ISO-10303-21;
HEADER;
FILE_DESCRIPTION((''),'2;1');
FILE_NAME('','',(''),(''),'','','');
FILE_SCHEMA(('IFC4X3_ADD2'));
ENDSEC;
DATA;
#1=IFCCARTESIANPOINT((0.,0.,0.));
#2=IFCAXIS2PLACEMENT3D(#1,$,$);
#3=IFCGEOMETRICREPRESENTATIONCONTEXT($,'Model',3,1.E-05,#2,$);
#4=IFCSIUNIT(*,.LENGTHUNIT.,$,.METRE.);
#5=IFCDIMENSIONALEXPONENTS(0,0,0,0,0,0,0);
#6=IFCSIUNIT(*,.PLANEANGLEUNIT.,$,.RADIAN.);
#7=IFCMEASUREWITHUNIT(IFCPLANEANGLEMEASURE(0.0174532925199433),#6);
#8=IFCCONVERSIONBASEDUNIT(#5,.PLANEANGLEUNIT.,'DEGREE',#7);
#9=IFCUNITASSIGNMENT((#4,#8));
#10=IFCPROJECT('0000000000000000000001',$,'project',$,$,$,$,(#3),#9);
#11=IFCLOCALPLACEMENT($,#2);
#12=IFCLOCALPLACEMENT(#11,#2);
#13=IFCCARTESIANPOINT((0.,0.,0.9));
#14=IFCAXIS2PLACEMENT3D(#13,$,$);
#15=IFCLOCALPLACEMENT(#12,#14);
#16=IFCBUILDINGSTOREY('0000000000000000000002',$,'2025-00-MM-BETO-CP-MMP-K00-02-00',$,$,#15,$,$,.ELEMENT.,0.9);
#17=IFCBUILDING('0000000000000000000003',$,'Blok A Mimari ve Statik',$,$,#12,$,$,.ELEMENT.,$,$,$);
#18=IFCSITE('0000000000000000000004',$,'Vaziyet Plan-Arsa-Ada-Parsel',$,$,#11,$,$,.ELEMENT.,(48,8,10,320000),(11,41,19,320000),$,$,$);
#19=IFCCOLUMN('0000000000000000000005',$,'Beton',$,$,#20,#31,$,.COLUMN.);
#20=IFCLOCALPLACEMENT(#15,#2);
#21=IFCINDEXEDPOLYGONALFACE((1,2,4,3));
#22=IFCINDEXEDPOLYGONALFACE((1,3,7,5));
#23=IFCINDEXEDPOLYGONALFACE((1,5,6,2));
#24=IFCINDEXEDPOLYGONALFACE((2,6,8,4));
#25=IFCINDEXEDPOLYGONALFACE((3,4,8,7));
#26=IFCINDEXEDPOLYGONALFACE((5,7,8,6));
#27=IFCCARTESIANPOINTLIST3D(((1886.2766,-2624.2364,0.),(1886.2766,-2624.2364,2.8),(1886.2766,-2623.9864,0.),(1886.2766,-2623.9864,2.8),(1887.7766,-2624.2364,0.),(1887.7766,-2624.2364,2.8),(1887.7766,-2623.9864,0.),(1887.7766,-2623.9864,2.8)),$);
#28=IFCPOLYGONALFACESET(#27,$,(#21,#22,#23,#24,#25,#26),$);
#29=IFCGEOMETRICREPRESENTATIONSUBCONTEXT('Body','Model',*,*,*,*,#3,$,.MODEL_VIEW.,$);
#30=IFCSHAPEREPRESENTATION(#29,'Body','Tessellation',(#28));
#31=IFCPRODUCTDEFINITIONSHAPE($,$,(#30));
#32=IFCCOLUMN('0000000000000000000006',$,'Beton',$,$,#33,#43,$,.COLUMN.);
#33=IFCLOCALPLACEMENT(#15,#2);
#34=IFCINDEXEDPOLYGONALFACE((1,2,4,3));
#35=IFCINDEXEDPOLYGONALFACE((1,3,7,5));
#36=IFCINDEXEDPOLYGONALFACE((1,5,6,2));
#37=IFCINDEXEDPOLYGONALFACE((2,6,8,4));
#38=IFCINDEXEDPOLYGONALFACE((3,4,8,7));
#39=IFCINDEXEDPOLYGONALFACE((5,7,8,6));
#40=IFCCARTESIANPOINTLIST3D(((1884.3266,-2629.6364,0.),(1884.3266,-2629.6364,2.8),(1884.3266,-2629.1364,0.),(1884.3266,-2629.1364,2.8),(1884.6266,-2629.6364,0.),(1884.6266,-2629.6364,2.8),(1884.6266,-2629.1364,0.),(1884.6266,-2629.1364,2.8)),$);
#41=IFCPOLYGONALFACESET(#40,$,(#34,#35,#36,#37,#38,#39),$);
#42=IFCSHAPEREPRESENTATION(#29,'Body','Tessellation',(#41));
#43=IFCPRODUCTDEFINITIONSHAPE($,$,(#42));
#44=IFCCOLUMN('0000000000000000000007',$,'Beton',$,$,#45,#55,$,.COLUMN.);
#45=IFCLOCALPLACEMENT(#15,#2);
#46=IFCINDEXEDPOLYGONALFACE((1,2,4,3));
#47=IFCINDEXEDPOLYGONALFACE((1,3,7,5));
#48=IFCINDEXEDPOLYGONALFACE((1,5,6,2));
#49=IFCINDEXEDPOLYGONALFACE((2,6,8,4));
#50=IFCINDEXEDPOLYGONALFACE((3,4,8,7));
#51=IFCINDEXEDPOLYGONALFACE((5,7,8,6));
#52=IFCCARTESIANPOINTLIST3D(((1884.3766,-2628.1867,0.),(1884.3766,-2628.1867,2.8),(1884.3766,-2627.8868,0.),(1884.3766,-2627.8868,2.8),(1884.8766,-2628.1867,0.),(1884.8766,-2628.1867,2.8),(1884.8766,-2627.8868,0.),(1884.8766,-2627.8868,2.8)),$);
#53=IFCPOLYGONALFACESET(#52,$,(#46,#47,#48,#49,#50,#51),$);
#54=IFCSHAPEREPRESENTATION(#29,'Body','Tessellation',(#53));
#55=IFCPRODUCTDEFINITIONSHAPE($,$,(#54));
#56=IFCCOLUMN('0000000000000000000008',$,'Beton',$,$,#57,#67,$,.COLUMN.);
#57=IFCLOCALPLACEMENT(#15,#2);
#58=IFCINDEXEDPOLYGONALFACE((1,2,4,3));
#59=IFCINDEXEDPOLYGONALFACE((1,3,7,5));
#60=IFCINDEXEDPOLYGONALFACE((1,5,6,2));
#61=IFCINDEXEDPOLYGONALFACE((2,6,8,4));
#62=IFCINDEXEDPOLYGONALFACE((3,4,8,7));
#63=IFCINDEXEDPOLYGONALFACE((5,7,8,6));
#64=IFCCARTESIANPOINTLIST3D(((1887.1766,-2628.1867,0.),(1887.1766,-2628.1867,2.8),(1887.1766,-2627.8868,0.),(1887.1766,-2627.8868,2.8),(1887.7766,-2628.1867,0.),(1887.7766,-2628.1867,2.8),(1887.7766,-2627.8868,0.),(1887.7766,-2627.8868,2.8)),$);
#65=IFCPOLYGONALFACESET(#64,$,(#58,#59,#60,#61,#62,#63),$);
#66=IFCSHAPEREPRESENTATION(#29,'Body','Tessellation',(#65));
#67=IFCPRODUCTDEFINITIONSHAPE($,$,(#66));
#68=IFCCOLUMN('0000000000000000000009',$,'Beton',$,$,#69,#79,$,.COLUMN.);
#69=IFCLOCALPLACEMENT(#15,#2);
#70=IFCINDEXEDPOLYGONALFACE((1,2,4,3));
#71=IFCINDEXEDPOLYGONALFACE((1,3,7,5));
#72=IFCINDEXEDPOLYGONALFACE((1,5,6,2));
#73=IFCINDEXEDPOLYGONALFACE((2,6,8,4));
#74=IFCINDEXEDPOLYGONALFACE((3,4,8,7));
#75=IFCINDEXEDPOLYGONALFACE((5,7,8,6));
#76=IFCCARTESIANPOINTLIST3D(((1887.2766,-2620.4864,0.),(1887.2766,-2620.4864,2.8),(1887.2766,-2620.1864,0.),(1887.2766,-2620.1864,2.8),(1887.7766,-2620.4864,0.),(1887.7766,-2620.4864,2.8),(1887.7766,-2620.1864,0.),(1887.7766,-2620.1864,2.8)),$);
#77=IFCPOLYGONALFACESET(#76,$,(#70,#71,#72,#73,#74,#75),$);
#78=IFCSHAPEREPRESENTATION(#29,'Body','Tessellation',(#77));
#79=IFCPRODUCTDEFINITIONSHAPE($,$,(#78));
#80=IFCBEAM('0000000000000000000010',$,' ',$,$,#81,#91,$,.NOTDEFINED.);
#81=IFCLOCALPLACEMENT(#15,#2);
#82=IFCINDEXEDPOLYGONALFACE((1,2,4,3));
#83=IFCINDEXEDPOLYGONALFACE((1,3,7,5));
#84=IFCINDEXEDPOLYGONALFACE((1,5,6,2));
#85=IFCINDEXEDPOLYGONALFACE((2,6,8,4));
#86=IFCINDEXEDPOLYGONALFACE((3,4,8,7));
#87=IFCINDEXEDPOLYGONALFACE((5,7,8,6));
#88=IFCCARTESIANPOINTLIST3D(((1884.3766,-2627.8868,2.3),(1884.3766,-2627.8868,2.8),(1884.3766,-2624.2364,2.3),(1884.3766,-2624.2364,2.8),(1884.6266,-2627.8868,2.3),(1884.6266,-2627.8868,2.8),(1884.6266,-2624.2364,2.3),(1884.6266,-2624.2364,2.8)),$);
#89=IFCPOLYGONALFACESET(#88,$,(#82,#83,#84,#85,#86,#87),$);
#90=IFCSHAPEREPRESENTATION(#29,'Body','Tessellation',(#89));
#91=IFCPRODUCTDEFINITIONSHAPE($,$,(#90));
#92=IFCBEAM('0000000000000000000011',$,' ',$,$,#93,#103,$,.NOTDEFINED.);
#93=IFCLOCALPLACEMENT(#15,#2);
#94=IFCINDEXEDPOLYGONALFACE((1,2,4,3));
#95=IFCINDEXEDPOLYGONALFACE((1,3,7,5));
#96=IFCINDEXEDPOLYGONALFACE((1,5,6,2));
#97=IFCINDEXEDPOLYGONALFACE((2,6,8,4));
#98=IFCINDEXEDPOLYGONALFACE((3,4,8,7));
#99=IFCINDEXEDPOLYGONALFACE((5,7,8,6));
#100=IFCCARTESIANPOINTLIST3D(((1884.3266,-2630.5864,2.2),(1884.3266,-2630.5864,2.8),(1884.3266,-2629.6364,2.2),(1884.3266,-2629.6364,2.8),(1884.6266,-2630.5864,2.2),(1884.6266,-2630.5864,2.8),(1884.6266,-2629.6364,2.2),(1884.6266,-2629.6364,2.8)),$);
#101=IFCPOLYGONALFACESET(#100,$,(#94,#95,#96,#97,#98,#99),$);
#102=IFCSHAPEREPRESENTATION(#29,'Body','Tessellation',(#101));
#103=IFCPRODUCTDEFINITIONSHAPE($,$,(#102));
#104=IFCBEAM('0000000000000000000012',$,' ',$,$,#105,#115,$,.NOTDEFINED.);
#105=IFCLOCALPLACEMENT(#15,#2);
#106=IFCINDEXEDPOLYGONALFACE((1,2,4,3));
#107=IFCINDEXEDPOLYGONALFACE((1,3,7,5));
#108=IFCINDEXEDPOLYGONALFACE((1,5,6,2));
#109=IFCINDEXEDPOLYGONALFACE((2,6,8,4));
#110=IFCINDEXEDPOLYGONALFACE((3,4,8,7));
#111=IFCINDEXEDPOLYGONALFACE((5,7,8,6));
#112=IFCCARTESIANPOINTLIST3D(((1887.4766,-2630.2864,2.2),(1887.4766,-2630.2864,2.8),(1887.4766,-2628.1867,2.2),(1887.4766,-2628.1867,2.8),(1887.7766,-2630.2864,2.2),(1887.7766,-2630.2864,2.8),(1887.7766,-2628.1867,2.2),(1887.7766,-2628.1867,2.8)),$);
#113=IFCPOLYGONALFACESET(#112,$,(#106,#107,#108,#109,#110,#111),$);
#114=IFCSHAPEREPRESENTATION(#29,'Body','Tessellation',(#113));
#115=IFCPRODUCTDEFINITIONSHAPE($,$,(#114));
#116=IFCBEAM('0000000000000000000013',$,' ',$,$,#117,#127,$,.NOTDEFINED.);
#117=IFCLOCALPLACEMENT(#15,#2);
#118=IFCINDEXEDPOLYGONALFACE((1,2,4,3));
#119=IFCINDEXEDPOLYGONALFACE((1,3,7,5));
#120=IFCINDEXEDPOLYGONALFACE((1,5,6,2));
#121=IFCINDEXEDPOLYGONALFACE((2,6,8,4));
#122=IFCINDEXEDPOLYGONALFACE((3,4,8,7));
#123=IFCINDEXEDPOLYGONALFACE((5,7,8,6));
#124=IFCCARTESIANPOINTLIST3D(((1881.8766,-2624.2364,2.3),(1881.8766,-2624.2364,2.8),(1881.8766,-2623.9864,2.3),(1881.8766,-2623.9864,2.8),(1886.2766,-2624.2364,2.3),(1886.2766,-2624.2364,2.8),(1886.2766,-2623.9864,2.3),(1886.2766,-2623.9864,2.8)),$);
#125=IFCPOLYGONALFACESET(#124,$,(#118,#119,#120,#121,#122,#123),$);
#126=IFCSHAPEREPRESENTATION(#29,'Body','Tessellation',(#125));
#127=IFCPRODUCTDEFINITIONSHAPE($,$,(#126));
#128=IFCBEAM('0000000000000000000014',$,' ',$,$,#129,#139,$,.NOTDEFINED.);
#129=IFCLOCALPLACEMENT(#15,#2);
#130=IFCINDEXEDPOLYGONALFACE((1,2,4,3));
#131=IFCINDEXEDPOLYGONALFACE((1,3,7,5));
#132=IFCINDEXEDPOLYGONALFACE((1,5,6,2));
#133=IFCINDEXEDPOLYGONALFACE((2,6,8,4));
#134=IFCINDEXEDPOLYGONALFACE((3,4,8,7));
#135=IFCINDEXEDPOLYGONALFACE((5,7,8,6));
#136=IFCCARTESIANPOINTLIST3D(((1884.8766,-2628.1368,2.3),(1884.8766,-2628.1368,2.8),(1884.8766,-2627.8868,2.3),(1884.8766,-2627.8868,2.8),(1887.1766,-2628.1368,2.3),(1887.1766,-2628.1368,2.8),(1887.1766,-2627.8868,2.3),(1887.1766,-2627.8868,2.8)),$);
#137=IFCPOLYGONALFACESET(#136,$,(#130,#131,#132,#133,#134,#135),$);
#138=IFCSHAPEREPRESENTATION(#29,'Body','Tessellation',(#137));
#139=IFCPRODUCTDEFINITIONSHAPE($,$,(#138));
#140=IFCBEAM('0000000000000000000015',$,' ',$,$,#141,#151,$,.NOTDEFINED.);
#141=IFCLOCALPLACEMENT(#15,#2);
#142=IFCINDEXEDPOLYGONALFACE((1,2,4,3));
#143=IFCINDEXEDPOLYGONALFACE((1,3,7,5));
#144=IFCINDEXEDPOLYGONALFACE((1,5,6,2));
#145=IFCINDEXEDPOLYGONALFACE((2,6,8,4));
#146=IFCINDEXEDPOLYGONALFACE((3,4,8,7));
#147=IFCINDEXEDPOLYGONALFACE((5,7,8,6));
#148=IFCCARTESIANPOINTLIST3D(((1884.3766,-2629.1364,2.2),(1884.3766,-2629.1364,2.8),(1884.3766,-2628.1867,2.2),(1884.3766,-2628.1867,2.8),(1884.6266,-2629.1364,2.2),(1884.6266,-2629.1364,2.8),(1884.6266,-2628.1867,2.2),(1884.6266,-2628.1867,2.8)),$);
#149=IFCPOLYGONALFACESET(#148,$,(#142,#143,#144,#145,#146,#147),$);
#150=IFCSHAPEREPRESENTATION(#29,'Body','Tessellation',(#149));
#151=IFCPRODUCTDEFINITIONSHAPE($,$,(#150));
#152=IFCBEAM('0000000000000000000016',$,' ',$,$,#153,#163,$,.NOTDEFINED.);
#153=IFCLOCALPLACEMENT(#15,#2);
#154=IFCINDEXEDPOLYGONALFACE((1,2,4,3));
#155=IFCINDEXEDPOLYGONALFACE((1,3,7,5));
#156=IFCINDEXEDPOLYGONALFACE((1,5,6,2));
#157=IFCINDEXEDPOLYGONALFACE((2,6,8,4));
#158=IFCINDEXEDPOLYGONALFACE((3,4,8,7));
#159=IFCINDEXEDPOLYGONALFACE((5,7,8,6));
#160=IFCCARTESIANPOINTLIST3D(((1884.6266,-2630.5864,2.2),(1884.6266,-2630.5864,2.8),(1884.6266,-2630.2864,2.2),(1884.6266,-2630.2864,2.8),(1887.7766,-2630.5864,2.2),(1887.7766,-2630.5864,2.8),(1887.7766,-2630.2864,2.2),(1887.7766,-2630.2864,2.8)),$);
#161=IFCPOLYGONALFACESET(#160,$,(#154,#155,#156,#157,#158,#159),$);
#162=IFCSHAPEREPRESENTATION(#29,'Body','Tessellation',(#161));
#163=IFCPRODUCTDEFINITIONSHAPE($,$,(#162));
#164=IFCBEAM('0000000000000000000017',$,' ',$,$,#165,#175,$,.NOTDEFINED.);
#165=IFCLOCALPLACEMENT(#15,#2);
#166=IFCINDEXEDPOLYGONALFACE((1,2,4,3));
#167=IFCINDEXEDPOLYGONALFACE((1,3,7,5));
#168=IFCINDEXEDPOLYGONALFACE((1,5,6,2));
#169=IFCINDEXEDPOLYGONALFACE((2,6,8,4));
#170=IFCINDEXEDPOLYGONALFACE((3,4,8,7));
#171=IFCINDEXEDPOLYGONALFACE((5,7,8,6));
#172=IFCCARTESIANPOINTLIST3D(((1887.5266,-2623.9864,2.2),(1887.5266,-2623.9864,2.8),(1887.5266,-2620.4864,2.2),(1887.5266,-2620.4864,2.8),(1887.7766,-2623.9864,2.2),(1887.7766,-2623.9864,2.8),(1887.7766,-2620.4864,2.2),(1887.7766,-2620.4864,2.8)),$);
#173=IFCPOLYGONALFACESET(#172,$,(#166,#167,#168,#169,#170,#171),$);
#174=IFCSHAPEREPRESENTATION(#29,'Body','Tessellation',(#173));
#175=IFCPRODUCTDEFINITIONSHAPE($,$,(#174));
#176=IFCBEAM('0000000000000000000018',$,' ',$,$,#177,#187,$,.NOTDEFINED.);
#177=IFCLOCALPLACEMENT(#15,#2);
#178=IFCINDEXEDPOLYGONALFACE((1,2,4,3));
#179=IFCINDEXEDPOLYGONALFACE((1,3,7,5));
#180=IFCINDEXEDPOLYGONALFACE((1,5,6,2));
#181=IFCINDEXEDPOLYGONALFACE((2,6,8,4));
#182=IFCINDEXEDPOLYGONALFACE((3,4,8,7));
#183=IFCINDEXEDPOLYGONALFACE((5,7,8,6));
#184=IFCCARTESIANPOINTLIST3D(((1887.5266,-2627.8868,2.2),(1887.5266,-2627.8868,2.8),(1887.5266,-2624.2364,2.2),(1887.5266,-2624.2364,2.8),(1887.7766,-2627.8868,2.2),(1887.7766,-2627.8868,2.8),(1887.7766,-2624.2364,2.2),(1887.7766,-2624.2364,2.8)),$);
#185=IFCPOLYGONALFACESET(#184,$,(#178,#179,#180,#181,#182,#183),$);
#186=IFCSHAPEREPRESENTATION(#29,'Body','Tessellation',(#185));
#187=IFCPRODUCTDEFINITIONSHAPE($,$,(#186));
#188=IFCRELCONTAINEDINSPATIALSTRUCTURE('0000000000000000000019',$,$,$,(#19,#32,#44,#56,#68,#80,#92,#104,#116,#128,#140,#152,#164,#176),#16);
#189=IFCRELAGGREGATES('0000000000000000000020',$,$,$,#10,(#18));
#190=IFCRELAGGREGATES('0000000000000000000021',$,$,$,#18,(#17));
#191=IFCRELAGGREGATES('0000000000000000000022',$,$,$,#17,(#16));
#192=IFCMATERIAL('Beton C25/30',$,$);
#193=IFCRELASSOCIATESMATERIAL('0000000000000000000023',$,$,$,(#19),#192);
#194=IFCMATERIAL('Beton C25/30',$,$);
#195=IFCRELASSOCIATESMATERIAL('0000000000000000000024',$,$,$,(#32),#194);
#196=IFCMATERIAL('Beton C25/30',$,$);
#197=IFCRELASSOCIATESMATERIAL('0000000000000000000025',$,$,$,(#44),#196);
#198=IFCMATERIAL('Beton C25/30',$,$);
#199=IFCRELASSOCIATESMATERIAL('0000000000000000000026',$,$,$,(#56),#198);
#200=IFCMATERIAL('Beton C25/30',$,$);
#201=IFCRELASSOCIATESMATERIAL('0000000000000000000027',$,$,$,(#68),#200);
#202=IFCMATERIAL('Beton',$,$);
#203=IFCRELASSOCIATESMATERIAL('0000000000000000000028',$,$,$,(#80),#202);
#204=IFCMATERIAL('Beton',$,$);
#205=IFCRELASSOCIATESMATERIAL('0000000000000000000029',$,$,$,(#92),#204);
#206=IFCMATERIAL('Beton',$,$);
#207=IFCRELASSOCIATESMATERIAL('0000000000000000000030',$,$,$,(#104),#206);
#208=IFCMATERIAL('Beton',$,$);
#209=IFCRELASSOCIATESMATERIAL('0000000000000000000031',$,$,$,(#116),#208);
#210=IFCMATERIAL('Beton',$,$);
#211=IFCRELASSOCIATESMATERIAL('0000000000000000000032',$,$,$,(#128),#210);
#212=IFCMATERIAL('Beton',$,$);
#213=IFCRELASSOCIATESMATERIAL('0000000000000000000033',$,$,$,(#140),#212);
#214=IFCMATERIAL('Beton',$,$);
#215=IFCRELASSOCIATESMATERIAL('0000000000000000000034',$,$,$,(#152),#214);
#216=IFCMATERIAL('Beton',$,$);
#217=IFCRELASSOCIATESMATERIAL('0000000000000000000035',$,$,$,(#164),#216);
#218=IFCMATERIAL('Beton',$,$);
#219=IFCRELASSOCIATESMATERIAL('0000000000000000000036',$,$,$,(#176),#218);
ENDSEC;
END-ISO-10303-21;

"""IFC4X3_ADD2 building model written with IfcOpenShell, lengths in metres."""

from ifc_helpers import new_model, entity, si_unit, converted_unit, frame, frame_2d, origin, origin_with_axes, place, context, subcontext, project, spatial, polyline, rectangle, outline, extrude, material, element, save


model = new_model("IFC4X3_ADD2")

# Units and contexts
model_context = context("Model", 3, precision=1e-05, world=origin())
body_context = subcontext(model_context, "Body", "Model", "MODEL_VIEW")
ifc_project = project(units=[si_unit("LENGTHUNIT", "METRE"), converted_unit("PLANEANGLEUNIT", "DEGREE", entity("IfcPlaneAngleMeasure", 0.0174532925199433), si_unit("PLANEANGLEUNIT", "RADIAN"), dimensions=[0, 0, 0, 0, 0, 0, 0])], contexts=[model_context])

# Site, building, storey
site_placement = place(None, origin())
site = spatial("IfcSite", under=ifc_project, at=site_placement, Name="Vaziyet Plan-Arsa-Ada-Parsel", CompositionType="ELEMENT", RefLatitude=(48, 8, 10, 320000), RefLongitude=(11, 41, 19, 320000))
building_placement = place(site_placement, origin())
building = spatial("IfcBuilding", under=site, at=building_placement, Name="Blok A Mimari ve Statik", CompositionType="ELEMENT")
storey_placement = place(building_placement, frame((0.0, 0.0, 0.9)))
storey = spatial("IfcBuildingStorey", under=building, at=storey_placement, Name="2025-00-MM-BETO-CP-MMP-K00-02-00", CompositionType="ELEMENT", Elevation=0.9)

# Columns
ifc_material_1 = material(Name="Beton C25/30")
column_1_placement = place(storey_placement, frame((1886.2766, -2624.2364, 0.0)))
element("IfcColumn", 1, at=column_1_placement, inside=storey, material=ifc_material_1, Name="Beton", PredefinedType="COLUMN", context=body_context, shape_type="SweptSolid", body=[
    extrude(outline(polyline([(1.5, 0.0), (1.5, 0.25), (0.0, 0.25), (0.0, 0.0), (1.5, 0.0)])), origin_with_axes(), (0.0, 0.0, 1.0), 2.8),
])
ifc_material_2 = material(Name="Beton C25/30")
column_2_placement = place(storey_placement, frame((1884.3266, -2629.6364, 0.0)))
element("IfcColumn", 2, at=column_2_placement, inside=storey, material=ifc_material_2, Name="Beton", PredefinedType="COLUMN", context=body_context, shape_type="SweptSolid", body=[
    extrude(outline(polyline([(0.0, 0.5), (0.0, 0.0), (0.3, 0.0), (0.3, 0.5), (0.0, 0.5)])), origin_with_axes(), (0.0, 0.0, 1.0), 2.8),
])
ifc_material_3 = material(Name="Beton C25/30")
column_3_placement = place(storey_placement, frame((1884.3766, -2628.1867, 0.0)))
element("IfcColumn", 3, at=column_3_placement, inside=storey, material=ifc_material_3, Name="Beton", PredefinedType="COLUMN", context=body_context, shape_type="SweptSolid", body=[
    extrude(outline(polyline([(0.0, 0.3), (0.0, 0.0), (0.5, 0.0), (0.5, 0.3), (0.0, 0.3)])), origin_with_axes(), (0.0, 0.0, 1.0), 2.8),
])
ifc_material_4 = material(Name="Beton C25/30")
column_4_placement = place(storey_placement, frame((1887.1766, -2628.1867, 0.0)))
element("IfcColumn", 4, at=column_4_placement, inside=storey, material=ifc_material_4, Name="Beton", PredefinedType="COLUMN", context=body_context, shape_type="SweptSolid", body=[
    extrude(outline(polyline([(0.0, 0.3), (0.0, 0.0), (0.6, 0.0), (0.6, 0.3), (0.0, 0.3)])), origin_with_axes(), (0.0, 0.0, 1.0), 2.8),
])
ifc_material_5 = material(Name="Beton C25/30")
column_5_placement = place(storey_placement, frame((1887.2766, -2620.4864, 0.0)))
element("IfcColumn", 5, at=column_5_placement, inside=storey, material=ifc_material_5, Name="Beton", PredefinedType="COLUMN", context=body_context, shape_type="SweptSolid", body=[
    extrude(outline(polyline([(0.0, 0.3), (0.0, 0.0), (0.5, 0.0), (0.5, 0.3), (0.0, 0.3)])), origin_with_axes(), (0.0, 0.0, 1.0), 2.8),
])

# Beams
ifc_material_6 = material(Name="Beton")
beam_1_placement = place(storey_placement, frame((1884.3766, -2624.2364, 2.3), z_axis=(0.0, 0.0, 1.0), x_axis=(0.0, -1.0, 0.0)))
element("IfcBeam", 6, at=beam_1_placement, inside=storey, material=ifc_material_6, Name=" ", PredefinedType="NOTDEFINED", context=body_context, shape_type="SweptSolid", body=[
    extrude(rectangle(XDim=0.25, YDim=0.5, at=frame_2d((0.125, 0.25), x_axis=(1.0, 0.0))), frame((0.0, 0.0, 0.0), z_axis=(1.0, 0.0, 0.0), x_axis=(0.0, 1.0, 0.0)), (0.0, 0.0, 1.0), 3.6503),
])
ifc_material_7 = material(Name="Beton")
beam_2_placement = place(storey_placement, frame((1884.3266, -2629.6364, 2.2), z_axis=(0.0, 0.0, 1.0), x_axis=(0.0, -1.0, 0.0)))
element("IfcBeam", 7, at=beam_2_placement, inside=storey, material=ifc_material_7, Name=" ", PredefinedType="NOTDEFINED", context=body_context, shape_type="SweptSolid", body=[
    extrude(rectangle(XDim=0.3, YDim=0.6, at=frame_2d((0.15, 0.3), x_axis=(1.0, 0.0))), frame((0.0, 0.0, 0.0), z_axis=(1.0, 0.0, 0.0), x_axis=(0.0, 1.0, 0.0)), (0.0, 0.0, 1.0), 0.95),
])
ifc_material_8 = material(Name="Beton")
beam_3_placement = place(storey_placement, frame((1887.7766, -2630.2864, 2.2), z_axis=(0.0, 0.0, 1.0), x_axis=(0.0, 1.0, 0.0)))
element("IfcBeam", 8, at=beam_3_placement, inside=storey, material=ifc_material_8, Name=" ", PredefinedType="NOTDEFINED", context=body_context, shape_type="SweptSolid", body=[
    extrude(rectangle(XDim=0.3, YDim=0.6, at=frame_2d((0.15, 0.3), x_axis=(1.0, 0.0))), frame((0.0, 0.0, 0.0), z_axis=(1.0, 0.0, 0.0), x_axis=(0.0, 1.0, 0.0)), (0.0, 0.0, 1.0), 2.0997),
])
ifc_material_9 = material(Name="Beton")
beam_4_placement = place(storey_placement, frame((1881.8766, -2624.2364, 2.3)))
element("IfcBeam", 9, at=beam_4_placement, inside=storey, material=ifc_material_9, Name=" ", PredefinedType="NOTDEFINED", context=body_context, shape_type="SweptSolid", body=[
    extrude(rectangle(XDim=0.25, YDim=0.5, at=frame_2d((0.125, 0.25), x_axis=(1.0, 0.0))), frame((0.0, 0.0, 0.0), z_axis=(1.0, 0.0, 0.0), x_axis=(0.0, 1.0, 0.0)), (0.0, 0.0, 1.0), 4.4),
])
ifc_material_10 = material(Name="Beton")
beam_5_placement = place(storey_placement, frame((1887.1766, -2627.8868, 2.3), z_axis=(0.0, 0.0, 1.0), x_axis=(-1.0, 0.0, 0.0)))
element("IfcBeam", 10, at=beam_5_placement, inside=storey, material=ifc_material_10, Name=" ", PredefinedType="NOTDEFINED", context=body_context, shape_type="SweptSolid", body=[
    extrude(rectangle(XDim=0.25, YDim=0.5, at=frame_2d((0.125, 0.25), x_axis=(1.0, 0.0))), frame((0.0, 0.0, 0.0), z_axis=(1.0, 0.0, 0.0), x_axis=(0.0, 1.0, 0.0)), (0.0, 0.0, 1.0), 2.3),
])
ifc_material_11 = material(Name="Beton")
beam_6_placement = place(storey_placement, frame((1884.6266, -2629.1364, 2.2), z_axis=(0.0, 0.0, 1.0), x_axis=(0.000003, 1.0, 0.0)))
element("IfcBeam", 11, at=beam_6_placement, inside=storey, material=ifc_material_11, Name=" ", PredefinedType="NOTDEFINED", context=body_context, shape_type="SweptSolid", body=[
    extrude(rectangle(XDim=0.25, YDim=0.6, at=frame_2d((0.125, 0.3), x_axis=(1.0, 0.0))), frame((0.0, 0.0, 0.0), z_axis=(1.0, 0.0, 0.0), x_axis=(0.0, 1.0, 0.0)), (0.0, 0.0, 1.0), 0.9497),
])
ifc_material_12 = material(Name="Beton")
beam_7_placement = place(storey_placement, frame((1884.6266, -2630.5864, 2.2)))
element("IfcBeam", 12, at=beam_7_placement, inside=storey, material=ifc_material_12, Name=" ", PredefinedType="NOTDEFINED", context=body_context, shape_type="SweptSolid", body=[
    extrude(rectangle(XDim=0.3, YDim=0.6, at=frame_2d((0.15, 0.3), x_axis=(1.0, 0.0))), frame((0.0, 0.0, 0.0), z_axis=(1.0, 0.0, 0.0), x_axis=(0.0, 1.0, 0.0)), (0.0, 0.0, 1.0), 3.15),
])
ifc_material_13 = material(Name="Beton")
beam_8_placement = place(storey_placement, frame((1887.7766, -2623.9864, 2.2), z_axis=(0.0, 0.0, 1.0), x_axis=(0.0, 1.0, 0.0)))
element("IfcBeam", 13, at=beam_8_placement, inside=storey, material=ifc_material_13, Name=" ", PredefinedType="NOTDEFINED", context=body_context, shape_type="SweptSolid", body=[
    extrude(rectangle(XDim=0.25, YDim=0.6, at=frame_2d((0.125, 0.3), x_axis=(1.0, 0.0))), frame((0.0, 0.0, 0.0), z_axis=(1.0, 0.0, 0.0), x_axis=(0.0, 1.0, 0.0)), (0.0, 0.0, 1.0), 3.5),
])
ifc_material_14 = material(Name="Beton")
beam_9_placement = place(storey_placement, frame((1887.7766, -2627.8868, 2.2), z_axis=(0.0, 0.0, 1.0), x_axis=(0.0, 1.0, 0.0)))
element("IfcBeam", 14, at=beam_9_placement, inside=storey, material=ifc_material_14, Name=" ", PredefinedType="NOTDEFINED", context=body_context, shape_type="SweptSolid", body=[
    extrude(rectangle(XDim=0.25, YDim=0.6, at=frame_2d((0.125, 0.3), x_axis=(1.0, 0.0))), frame((0.0, 0.0, 0.0), z_axis=(1.0, 0.0, 0.0), x_axis=(0.0, 1.0, 0.0)), (0.0, 0.0, 1.0), 3.6503),
])

save(model, "model.ifc")
